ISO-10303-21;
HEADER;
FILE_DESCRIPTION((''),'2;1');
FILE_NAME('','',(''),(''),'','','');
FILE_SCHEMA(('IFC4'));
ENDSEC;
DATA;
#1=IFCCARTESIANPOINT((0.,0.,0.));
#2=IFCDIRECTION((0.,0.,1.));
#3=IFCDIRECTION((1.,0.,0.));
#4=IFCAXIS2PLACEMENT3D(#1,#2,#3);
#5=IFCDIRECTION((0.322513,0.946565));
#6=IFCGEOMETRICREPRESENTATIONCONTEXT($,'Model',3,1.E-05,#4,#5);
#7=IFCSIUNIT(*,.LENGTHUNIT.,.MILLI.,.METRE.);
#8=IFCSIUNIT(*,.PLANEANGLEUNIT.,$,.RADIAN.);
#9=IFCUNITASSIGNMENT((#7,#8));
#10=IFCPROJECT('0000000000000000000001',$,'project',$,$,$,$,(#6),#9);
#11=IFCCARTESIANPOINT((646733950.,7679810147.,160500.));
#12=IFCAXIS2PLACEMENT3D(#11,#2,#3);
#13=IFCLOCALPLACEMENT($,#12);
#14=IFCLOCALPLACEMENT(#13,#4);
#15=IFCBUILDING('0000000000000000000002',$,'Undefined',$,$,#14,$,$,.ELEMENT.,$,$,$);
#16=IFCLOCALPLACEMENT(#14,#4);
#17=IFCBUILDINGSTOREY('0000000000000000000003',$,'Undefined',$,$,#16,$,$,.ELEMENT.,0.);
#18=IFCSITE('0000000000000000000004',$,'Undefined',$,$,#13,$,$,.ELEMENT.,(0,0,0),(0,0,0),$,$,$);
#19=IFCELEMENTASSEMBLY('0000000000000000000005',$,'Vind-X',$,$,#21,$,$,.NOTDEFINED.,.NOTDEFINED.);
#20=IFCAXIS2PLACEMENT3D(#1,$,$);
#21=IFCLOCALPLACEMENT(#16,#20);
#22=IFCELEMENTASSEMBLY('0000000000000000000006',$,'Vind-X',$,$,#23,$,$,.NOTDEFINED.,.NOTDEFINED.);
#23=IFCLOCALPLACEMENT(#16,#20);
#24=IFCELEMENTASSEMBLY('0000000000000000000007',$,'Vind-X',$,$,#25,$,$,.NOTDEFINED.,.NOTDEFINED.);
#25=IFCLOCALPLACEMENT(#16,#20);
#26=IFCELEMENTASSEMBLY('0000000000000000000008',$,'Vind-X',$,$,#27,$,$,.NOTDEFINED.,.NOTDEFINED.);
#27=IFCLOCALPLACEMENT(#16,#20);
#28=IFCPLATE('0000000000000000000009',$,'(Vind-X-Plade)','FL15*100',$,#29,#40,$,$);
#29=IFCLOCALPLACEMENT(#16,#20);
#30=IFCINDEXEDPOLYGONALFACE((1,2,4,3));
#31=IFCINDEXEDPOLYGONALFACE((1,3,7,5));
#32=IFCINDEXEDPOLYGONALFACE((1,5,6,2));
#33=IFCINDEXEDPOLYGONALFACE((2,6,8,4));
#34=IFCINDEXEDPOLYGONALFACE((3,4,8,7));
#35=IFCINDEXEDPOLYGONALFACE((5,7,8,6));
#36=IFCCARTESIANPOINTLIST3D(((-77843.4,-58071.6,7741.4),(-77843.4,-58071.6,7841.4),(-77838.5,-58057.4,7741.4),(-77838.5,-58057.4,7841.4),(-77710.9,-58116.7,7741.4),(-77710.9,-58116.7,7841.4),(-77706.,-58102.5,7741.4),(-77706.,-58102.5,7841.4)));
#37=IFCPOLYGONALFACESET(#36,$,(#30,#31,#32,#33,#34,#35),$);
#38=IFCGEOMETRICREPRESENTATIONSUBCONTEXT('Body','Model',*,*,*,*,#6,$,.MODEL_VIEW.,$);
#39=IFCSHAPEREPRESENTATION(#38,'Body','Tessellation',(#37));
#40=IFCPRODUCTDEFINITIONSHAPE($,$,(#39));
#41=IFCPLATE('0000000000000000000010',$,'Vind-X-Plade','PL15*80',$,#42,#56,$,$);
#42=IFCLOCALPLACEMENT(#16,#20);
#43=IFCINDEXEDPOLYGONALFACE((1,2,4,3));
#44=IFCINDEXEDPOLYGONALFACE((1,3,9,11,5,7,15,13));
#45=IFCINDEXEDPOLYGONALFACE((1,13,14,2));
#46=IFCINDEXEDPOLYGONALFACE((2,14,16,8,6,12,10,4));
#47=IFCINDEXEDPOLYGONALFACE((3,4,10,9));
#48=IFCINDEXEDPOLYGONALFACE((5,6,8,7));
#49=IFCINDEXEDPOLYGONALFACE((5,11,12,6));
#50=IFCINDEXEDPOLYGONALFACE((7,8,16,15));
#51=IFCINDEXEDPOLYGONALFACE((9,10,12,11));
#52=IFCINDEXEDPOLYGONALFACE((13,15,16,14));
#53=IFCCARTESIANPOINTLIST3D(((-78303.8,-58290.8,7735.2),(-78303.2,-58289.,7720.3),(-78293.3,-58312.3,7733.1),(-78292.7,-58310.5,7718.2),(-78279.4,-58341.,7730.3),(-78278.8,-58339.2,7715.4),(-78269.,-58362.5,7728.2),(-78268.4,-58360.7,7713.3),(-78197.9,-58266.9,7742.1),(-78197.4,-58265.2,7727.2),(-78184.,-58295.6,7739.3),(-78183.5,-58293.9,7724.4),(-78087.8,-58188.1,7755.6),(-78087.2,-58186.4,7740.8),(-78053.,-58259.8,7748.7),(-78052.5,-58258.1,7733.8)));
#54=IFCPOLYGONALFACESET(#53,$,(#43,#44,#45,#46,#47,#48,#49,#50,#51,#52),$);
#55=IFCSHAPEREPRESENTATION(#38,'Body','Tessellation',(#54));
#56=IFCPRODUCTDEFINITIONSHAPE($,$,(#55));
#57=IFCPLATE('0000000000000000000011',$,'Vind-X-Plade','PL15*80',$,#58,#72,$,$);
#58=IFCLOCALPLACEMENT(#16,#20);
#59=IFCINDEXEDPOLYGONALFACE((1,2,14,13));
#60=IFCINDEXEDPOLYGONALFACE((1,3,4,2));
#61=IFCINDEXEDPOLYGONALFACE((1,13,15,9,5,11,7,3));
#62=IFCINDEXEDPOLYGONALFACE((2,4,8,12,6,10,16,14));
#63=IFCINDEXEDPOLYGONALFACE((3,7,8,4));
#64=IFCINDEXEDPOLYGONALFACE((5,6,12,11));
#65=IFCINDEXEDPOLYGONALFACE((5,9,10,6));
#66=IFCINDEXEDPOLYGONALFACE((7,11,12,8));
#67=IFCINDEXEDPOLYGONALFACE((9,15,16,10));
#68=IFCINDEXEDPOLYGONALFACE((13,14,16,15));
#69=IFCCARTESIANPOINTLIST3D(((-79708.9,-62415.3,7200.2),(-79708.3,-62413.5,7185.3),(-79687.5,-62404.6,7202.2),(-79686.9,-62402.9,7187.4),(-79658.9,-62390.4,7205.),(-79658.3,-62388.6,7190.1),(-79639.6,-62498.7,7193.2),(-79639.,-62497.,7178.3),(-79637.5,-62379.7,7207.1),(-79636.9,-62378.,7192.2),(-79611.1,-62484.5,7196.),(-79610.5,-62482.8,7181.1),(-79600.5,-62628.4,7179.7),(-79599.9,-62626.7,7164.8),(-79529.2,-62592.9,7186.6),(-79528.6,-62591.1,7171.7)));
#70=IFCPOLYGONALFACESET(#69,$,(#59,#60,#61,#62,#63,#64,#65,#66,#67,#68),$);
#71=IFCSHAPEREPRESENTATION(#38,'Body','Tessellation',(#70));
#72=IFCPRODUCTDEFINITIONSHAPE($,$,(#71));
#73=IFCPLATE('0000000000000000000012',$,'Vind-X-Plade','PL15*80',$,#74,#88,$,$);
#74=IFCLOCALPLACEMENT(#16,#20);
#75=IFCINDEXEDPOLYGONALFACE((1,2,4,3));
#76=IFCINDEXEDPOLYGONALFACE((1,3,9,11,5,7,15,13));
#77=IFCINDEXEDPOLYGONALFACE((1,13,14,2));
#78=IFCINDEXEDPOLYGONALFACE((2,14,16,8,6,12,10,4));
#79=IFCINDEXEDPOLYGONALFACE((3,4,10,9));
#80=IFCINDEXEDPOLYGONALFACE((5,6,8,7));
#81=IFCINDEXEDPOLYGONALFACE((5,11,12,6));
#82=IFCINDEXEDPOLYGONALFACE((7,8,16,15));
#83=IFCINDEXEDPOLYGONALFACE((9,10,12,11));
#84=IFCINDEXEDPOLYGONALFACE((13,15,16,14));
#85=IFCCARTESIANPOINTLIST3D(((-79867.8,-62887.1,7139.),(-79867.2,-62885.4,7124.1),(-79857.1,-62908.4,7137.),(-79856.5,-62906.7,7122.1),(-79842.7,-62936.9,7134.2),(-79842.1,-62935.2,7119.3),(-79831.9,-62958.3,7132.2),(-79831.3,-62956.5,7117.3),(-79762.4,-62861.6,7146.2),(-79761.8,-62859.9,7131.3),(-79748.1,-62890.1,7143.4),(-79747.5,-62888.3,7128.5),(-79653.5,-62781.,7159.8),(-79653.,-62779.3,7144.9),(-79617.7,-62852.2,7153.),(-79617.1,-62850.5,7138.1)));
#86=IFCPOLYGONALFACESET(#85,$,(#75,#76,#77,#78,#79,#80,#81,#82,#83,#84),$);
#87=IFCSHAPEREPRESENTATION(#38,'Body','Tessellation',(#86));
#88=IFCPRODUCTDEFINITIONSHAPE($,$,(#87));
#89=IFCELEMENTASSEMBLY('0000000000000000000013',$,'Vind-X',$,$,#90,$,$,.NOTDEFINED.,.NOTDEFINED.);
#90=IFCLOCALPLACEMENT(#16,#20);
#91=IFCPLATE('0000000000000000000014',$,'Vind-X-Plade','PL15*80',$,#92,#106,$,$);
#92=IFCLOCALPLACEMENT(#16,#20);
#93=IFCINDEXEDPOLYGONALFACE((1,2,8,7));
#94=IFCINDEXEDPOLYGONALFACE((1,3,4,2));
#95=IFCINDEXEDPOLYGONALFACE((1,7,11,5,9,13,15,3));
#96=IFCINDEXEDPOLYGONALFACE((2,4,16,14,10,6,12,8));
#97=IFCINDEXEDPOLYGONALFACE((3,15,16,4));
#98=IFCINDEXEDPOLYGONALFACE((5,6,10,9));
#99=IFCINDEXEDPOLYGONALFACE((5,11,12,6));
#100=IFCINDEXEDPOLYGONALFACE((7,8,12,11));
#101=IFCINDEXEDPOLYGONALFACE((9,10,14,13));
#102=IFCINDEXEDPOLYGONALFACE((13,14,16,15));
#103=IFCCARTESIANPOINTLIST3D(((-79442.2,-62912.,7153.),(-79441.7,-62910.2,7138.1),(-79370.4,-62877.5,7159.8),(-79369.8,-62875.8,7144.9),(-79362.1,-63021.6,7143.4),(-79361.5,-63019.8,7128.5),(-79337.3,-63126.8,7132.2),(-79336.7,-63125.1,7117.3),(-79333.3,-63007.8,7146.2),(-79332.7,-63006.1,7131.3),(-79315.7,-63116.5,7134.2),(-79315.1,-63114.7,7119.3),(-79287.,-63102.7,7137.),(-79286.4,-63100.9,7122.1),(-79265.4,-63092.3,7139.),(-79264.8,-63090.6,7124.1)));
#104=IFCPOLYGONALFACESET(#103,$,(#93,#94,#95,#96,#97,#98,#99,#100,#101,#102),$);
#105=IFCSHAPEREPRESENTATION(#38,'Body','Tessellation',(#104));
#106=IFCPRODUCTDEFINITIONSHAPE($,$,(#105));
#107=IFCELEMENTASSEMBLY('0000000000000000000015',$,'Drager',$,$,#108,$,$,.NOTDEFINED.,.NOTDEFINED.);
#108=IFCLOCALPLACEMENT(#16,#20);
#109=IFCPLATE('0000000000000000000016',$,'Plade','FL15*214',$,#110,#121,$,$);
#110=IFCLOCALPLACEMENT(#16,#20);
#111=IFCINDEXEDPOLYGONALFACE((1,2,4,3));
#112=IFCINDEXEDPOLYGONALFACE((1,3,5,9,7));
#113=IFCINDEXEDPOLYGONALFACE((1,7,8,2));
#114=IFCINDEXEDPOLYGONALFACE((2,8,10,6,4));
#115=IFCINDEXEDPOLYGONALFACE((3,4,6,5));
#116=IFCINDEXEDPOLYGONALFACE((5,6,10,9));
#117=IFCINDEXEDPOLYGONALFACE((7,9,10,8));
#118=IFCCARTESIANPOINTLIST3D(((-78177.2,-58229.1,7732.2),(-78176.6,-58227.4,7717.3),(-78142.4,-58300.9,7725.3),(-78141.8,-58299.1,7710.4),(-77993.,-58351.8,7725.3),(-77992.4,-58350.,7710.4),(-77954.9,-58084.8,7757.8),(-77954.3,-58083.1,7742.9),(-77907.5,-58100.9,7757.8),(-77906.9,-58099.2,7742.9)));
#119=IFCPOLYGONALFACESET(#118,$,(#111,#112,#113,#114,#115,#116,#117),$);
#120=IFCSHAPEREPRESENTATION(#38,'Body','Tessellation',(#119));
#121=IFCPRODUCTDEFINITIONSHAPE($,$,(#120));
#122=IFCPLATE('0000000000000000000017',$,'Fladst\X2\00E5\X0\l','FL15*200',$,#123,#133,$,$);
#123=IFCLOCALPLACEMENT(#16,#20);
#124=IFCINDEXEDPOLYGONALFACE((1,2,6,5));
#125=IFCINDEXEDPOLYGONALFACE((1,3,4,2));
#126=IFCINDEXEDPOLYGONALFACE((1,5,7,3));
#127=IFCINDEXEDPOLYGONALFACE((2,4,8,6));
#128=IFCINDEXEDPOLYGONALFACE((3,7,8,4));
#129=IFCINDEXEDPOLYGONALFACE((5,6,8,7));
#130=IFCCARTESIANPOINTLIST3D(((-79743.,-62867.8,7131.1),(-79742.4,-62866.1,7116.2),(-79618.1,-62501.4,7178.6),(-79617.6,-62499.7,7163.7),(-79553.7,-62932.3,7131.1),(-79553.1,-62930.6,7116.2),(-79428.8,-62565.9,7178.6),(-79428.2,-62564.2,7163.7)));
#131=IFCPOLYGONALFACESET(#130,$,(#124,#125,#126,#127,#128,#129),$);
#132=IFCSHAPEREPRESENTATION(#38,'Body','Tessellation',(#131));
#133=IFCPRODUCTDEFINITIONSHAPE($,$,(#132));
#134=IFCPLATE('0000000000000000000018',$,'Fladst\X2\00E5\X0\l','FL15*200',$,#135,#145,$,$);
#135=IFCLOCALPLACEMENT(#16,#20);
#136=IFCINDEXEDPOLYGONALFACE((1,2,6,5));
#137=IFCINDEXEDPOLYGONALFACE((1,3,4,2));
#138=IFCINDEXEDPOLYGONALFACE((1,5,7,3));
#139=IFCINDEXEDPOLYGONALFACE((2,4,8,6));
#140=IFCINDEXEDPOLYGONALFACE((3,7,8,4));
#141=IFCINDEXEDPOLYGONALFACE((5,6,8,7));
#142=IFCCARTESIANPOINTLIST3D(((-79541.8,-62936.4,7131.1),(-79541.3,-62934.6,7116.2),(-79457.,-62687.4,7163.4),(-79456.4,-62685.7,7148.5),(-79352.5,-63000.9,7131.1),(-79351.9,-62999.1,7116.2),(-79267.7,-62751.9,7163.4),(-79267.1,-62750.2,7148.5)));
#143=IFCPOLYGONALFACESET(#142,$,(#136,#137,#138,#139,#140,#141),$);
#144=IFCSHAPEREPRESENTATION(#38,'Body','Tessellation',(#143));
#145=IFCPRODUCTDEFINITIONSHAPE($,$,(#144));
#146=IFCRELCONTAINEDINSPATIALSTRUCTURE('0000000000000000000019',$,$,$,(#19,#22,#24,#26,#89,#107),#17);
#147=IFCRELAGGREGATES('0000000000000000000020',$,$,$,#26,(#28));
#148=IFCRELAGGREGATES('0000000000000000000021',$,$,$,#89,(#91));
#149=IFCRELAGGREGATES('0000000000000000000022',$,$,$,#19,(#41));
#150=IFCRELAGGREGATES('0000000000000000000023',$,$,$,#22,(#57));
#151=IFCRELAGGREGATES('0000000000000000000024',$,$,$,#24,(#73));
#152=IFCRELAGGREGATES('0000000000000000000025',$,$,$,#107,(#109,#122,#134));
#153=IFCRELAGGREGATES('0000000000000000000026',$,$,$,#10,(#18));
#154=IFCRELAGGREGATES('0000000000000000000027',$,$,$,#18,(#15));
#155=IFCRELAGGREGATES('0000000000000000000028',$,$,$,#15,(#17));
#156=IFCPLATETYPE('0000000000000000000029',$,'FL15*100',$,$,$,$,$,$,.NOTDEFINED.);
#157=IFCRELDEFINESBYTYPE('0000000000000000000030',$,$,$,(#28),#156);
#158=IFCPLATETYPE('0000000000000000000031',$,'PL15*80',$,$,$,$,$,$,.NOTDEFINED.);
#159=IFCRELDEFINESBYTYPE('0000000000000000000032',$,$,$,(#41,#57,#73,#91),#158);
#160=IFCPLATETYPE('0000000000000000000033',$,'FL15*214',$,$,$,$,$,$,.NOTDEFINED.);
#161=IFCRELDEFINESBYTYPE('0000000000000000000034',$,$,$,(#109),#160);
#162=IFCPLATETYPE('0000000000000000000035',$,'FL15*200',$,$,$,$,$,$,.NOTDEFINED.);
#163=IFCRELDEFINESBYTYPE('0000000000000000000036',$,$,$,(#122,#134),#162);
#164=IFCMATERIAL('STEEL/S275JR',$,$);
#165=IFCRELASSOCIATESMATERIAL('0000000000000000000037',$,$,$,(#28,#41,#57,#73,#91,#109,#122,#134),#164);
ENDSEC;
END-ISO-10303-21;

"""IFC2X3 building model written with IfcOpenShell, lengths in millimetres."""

from ifc_helpers import new_model, si_unit, direction, frame, origin_with_axes, place, context, subcontext, project, spatial, polyline, outline, extrude, boolean, material, type_object, element, aggregate, save


model = new_model("IFC2X3")

# Units and contexts
model_context = context("Model", 3, precision=1e-05, world=origin_with_axes(), true_north=direction((0.322513, 0.946565)))
body_context = subcontext(model_context, "Body", "Model", "MODEL_VIEW")
ifc_project = project(units=[si_unit("LENGTHUNIT", "METRE", prefix="MILLI"), si_unit("PLANEANGLEUNIT", "RADIAN")], contexts=[model_context])

# Site, building, storey
site_placement = place(None, frame((646733950.0, 7679810147.0, 160500.0), z_axis=(0.0, 0.0, 1.0), x_axis=(1.0, 0.0, 0.0)))
site = spatial("IfcSite", under=ifc_project, at=site_placement, Name="Undefined", CompositionType="ELEMENT", RefLatitude=(0, 0, 0), RefLongitude=(0, 0, 0))
building_placement = place(site_placement, origin_with_axes())
building = spatial("IfcBuilding", under=site, at=building_placement, Name="Undefined", CompositionType="ELEMENT")
storey_placement = place(building_placement, origin_with_axes())
storey = spatial("IfcBuildingStorey", under=building, at=storey_placement, Name="Undefined", CompositionType="ELEMENT", Elevation=0.0)

# Element assemblies
assembly_1_placement = place(storey_placement, origin_with_axes())
assembly_1 = element("IfcElementAssembly", 1, at=assembly_1_placement, inside=storey, Name="Vind-X", AssemblyPlace="NOTDEFINED", PredefinedType="NOTDEFINED")
assembly_2_placement = place(storey_placement, origin_with_axes())
assembly_2 = element("IfcElementAssembly", 2, at=assembly_2_placement, inside=storey, Name="Vind-X", AssemblyPlace="NOTDEFINED", PredefinedType="NOTDEFINED")

# Element assembly
assembly_3_placement = place(storey_placement, origin_with_axes())
assembly_3 = element("IfcElementAssembly", 3, at=assembly_3_placement, inside=storey, Name="Vind-X", AssemblyPlace="NOTDEFINED", PredefinedType="NOTDEFINED")

# Shared definitions
ifc_material_1 = material(Name="STEEL/S275JR")

# Element assembly
assembly_4_placement = place(storey_placement, origin_with_axes())
assembly_4 = element("IfcElementAssembly", 4, at=assembly_4_placement, inside=storey, Name="Vind-X", AssemblyPlace="NOTDEFINED", PredefinedType="NOTDEFINED")

# Plates
plate_type_1 = type_object("IfcPlateType", Name="FL15*100", PredefinedType="NOTDEFINED")
plate_1_placement = place(assembly_4_placement, frame((-77841.0, -58064.5, 7741.4), z_axis=(0.322513, 0.946565, 0.0), x_axis=(0.0, 0.0, 1.0)))
plate_1 = element("IfcPlate", 5, at=plate_1_placement, type_object=plate_type_1, material=ifc_material_1, Name="(Vind-X-Plade)", Description="FL15*100", context=body_context, shape_type="SweptSolid", body=[
    extrude(outline(polyline([(0.0, 0.0), (100.0, 0.0), (100.0, 140.0), (0.0, 140.0), (0.0, 0.0)])), frame((0.0, 0.0, -7.5), z_axis=(0.0, 0.0, 1.0), x_axis=(1.0, 0.0, 0.0)), (0.0, 0.0, 1.0), 15.0),
])
aggregate(assembly_4, [plate_1])
plate_type_2 = type_object("IfcPlateType", Name="PL15*80", PredefinedType="NOTDEFINED")
plate_2_placement = place(assembly_1_placement, frame((-78268.7, -58361.6, 7720.8), z_axis=(-0.039304, -0.115357, 0.992546), x_axis=(0.899843, 0.427783, 0.085352)))
plate_2 = element("IfcPlate", 6, at=plate_2_placement, type_object=plate_type_2, material=ifc_material_1, Name="Vind-X-Plade", Description="PL15*80", context=body_context, shape_type="SweptSolid", body=[
    extrude(outline(polyline([(0.0, 0.0), (240.0, 0.0), (240.0, 80.0), (0.0, 80.0), (0.0, 56.0), (106.0, 56.0), (106.0, 24.0), (0.0, 24.0), (0.0, 0.0)])), frame((0.0, 0.0, -7.5), z_axis=(0.0, 0.0, 1.0), x_axis=(1.0, 0.0, 0.0)), (0.0, 0.0, 1.0), 15.0),
])
plate_3_placement = place(assembly_2_placement, frame((-79600.2, -62627.6, 7172.2), z_axis=(-0.039304, -0.115357, 0.992546), x_axis=(0.891424, 0.444742, 0.08699)))
plate_3 = element("IfcPlate", 7, at=plate_3_placement, type_object=plate_type_2, material=ifc_material_1, Name="Vind-X-Plade", Description="PL15*80", context=body_context, shape_type="CSG", body=[
    boolean("DIFFERENCE", extrude(outline(polyline([(0.0, 0.0), (80.0, 0.0), (80.0, 240.0), (0.0, 240.0), (0.0, 0.0)])), frame((0.0, 0.0, -7.5), z_axis=(0.0, 0.0, 1.0), x_axis=(1.0, 0.0, 0.0)), (0.0, 0.0, 1.0), 15.0), extrude(outline(polyline([(0.0, 0.0), (106.0, 0.0), (106.0, 32.0), (0.0, 32.0), (0.0, 0.0)])), frame((56.0, 240.0, 8.5), z_axis=(0.0, 0.0, -1.0), x_axis=(0.0, -1.0, 0.0)), (0.0, 0.0, 1.0), 17.0)),
])
plate_4_placement = place(assembly_3_placement, frame((-79617.4, -62851.3, 7145.5), z_axis=(-0.039304, -0.115357, 0.992546), x_axis=(-0.448662, 0.88959, 0.085625)))
plate_4 = element("IfcPlate", 8, at=plate_4_placement, type_object=plate_type_2, material=ifc_material_1, Name="Vind-X-Plade", Description="PL15*80", context=body_context, shape_type="CSG", body=[
    boolean("DIFFERENCE", extrude(outline(polyline([(0.0, 0.0), (80.0, 0.0), (80.0, 240.0), (0.0, 240.0), (0.0, 0.0)])), frame((0.0, 0.0, -7.5), z_axis=(0.0, 0.0, 1.0), x_axis=(1.0, 0.0, 0.0)), (0.0, 0.0, 1.0), 15.0), extrude(outline(polyline([(0.0, 0.0), (106.0, 0.0), (106.0, 32.0), (0.0, 32.0), (0.0, 0.0)])), frame((56.0, 240.0, 8.5), z_axis=(0.0, 0.0, -1.0), x_axis=(0.0, -1.0, 0.0)), (0.0, 0.0, 1.0), 17.0)),
])

# Element assembly, plate
assembly_5_placement = place(storey_placement, origin_with_axes())
assembly_5 = element("IfcElementAssembly", 9, at=assembly_5_placement, inside=storey, Name="Vind-X", AssemblyPlace="NOTDEFINED", PredefinedType="NOTDEFINED")
plate_5_placement = place(assembly_5_placement, frame((-79442.0, -62911.1, 7145.5), z_axis=(0.039304, 0.115357, -0.992546), x_axis=(0.898474, 0.430595, 0.085625)))
plate_5 = element("IfcPlate", 10, at=plate_5_placement, type_object=plate_type_2, material=ifc_material_1, Name="Vind-X-Plade", Description="PL15*80", context=body_context, shape_type="CSG", body=[
    boolean("DIFFERENCE", extrude(outline(polyline([(0.0, 0.0), (80.0, 0.0), (80.0, 240.0), (0.0, 240.0), (0.0, 0.0)])), frame((0.0, 0.0, -7.5), z_axis=(0.0, 0.0, 1.0), x_axis=(1.0, 0.0, 0.0)), (0.0, 0.0, 1.0), 15.0), extrude(outline(polyline([(0.0, 0.0), (106.0, 0.0), (106.0, 32.0), (0.0, 32.0), (0.0, 0.0)])), frame((56.0, 240.0, 8.5), z_axis=(0.0, 0.0, -1.0), x_axis=(0.0, -1.0, 0.0)), (0.0, 0.0, 1.0), 17.0)),
])
aggregate(assembly_5, [plate_5])

# Element assembly, plates
assembly_6_placement = place(storey_placement, origin_with_axes())
assembly_6 = element("IfcElementAssembly", 11, at=assembly_6_placement, inside=storey, Name="Drager", AssemblyPlace="NOTDEFINED", PredefinedType="NOTDEFINED")
plate_type_3 = type_object("IfcPlateType", Name="FL15*214", PredefinedType="NOTDEFINED")
plate_6_placement = place(assembly_6_placement, frame((-77992.7, -58350.9, 7717.8), z_axis=(-0.039304, -0.115357, 0.992546), x_axis=(0.320109, 0.93951, 0.121869)))
plate_6 = element("IfcPlate", 12, at=plate_6_placement, type_object=plate_type_3, material=ifc_material_1, Name="Plade", Description="FL15*214", context=body_context, shape_type="SweptSolid", body=[
    extrude(outline(polyline([(0.0, 0.0), (267.0, 0.0), (267.0, 50.0), (57.1, 213.9), (0.0, 157.9), (0.0, 0.0)])), frame((0.0, 0.0, -7.5), z_axis=(0.0, 0.0, 1.0), x_axis=(1.0, 0.0, 0.0)), (0.0, 0.0, 1.0), 15.0),
])
plate_type_4 = type_object("IfcPlateType", Name="FL15*200", PredefinedType="NOTDEFINED")
plate_7_placement = place(assembly_6_placement, frame((-79553.4, -62931.5, 7123.6), z_axis=(-0.039304, -0.115357, 0.992546), x_axis=(0.320109, 0.93951, 0.121869)))
plate_7 = element("IfcPlate", 13, at=plate_7_placement, type_object=plate_type_4, material=ifc_material_1, Name="Fladstål", Description="FL15*200", context=body_context, shape_type="SweptSolid", body=[
    extrude(outline(polyline([(0.0, 0.0), (390.0, 0.0), (390.0, 200.0), (0.0, 200.0), (0.0, 0.0)])), frame((0.0, 0.0, -7.5), z_axis=(0.0, 0.0, 1.0), x_axis=(1.0, 0.0, 0.0)), (0.0, 0.0, 1.0), 15.0),
])
plate_8_placement = place(assembly_6_placement, frame((-79456.7, -62686.5, 7155.9), z_axis=(-0.039304, -0.115357, 0.992546), x_axis=(-0.320109, -0.93951, -0.121869)))
plate_8 = element("IfcPlate", 14, at=plate_8_placement, type_object=plate_type_4, material=ifc_material_1, Name="Fladstål", Description="FL15*200", context=body_context, shape_type="SweptSolid", body=[
    extrude(outline(polyline([(0.0, 0.0), (265.0, 0.0), (265.0, 200.0), (0.0, 200.0), (0.0, 0.0)])), frame((0.0, 0.0, -7.5), z_axis=(0.0, 0.0, 1.0), x_axis=(1.0, 0.0, 0.0)), (0.0, 0.0, 1.0), 15.0),
])

aggregate(assembly_1, [plate_2])
aggregate(assembly_2, [plate_3])
aggregate(assembly_3, [plate_4])
aggregate(assembly_6, [plate_6, plate_7, plate_8])

save(model, "model.ifc")
